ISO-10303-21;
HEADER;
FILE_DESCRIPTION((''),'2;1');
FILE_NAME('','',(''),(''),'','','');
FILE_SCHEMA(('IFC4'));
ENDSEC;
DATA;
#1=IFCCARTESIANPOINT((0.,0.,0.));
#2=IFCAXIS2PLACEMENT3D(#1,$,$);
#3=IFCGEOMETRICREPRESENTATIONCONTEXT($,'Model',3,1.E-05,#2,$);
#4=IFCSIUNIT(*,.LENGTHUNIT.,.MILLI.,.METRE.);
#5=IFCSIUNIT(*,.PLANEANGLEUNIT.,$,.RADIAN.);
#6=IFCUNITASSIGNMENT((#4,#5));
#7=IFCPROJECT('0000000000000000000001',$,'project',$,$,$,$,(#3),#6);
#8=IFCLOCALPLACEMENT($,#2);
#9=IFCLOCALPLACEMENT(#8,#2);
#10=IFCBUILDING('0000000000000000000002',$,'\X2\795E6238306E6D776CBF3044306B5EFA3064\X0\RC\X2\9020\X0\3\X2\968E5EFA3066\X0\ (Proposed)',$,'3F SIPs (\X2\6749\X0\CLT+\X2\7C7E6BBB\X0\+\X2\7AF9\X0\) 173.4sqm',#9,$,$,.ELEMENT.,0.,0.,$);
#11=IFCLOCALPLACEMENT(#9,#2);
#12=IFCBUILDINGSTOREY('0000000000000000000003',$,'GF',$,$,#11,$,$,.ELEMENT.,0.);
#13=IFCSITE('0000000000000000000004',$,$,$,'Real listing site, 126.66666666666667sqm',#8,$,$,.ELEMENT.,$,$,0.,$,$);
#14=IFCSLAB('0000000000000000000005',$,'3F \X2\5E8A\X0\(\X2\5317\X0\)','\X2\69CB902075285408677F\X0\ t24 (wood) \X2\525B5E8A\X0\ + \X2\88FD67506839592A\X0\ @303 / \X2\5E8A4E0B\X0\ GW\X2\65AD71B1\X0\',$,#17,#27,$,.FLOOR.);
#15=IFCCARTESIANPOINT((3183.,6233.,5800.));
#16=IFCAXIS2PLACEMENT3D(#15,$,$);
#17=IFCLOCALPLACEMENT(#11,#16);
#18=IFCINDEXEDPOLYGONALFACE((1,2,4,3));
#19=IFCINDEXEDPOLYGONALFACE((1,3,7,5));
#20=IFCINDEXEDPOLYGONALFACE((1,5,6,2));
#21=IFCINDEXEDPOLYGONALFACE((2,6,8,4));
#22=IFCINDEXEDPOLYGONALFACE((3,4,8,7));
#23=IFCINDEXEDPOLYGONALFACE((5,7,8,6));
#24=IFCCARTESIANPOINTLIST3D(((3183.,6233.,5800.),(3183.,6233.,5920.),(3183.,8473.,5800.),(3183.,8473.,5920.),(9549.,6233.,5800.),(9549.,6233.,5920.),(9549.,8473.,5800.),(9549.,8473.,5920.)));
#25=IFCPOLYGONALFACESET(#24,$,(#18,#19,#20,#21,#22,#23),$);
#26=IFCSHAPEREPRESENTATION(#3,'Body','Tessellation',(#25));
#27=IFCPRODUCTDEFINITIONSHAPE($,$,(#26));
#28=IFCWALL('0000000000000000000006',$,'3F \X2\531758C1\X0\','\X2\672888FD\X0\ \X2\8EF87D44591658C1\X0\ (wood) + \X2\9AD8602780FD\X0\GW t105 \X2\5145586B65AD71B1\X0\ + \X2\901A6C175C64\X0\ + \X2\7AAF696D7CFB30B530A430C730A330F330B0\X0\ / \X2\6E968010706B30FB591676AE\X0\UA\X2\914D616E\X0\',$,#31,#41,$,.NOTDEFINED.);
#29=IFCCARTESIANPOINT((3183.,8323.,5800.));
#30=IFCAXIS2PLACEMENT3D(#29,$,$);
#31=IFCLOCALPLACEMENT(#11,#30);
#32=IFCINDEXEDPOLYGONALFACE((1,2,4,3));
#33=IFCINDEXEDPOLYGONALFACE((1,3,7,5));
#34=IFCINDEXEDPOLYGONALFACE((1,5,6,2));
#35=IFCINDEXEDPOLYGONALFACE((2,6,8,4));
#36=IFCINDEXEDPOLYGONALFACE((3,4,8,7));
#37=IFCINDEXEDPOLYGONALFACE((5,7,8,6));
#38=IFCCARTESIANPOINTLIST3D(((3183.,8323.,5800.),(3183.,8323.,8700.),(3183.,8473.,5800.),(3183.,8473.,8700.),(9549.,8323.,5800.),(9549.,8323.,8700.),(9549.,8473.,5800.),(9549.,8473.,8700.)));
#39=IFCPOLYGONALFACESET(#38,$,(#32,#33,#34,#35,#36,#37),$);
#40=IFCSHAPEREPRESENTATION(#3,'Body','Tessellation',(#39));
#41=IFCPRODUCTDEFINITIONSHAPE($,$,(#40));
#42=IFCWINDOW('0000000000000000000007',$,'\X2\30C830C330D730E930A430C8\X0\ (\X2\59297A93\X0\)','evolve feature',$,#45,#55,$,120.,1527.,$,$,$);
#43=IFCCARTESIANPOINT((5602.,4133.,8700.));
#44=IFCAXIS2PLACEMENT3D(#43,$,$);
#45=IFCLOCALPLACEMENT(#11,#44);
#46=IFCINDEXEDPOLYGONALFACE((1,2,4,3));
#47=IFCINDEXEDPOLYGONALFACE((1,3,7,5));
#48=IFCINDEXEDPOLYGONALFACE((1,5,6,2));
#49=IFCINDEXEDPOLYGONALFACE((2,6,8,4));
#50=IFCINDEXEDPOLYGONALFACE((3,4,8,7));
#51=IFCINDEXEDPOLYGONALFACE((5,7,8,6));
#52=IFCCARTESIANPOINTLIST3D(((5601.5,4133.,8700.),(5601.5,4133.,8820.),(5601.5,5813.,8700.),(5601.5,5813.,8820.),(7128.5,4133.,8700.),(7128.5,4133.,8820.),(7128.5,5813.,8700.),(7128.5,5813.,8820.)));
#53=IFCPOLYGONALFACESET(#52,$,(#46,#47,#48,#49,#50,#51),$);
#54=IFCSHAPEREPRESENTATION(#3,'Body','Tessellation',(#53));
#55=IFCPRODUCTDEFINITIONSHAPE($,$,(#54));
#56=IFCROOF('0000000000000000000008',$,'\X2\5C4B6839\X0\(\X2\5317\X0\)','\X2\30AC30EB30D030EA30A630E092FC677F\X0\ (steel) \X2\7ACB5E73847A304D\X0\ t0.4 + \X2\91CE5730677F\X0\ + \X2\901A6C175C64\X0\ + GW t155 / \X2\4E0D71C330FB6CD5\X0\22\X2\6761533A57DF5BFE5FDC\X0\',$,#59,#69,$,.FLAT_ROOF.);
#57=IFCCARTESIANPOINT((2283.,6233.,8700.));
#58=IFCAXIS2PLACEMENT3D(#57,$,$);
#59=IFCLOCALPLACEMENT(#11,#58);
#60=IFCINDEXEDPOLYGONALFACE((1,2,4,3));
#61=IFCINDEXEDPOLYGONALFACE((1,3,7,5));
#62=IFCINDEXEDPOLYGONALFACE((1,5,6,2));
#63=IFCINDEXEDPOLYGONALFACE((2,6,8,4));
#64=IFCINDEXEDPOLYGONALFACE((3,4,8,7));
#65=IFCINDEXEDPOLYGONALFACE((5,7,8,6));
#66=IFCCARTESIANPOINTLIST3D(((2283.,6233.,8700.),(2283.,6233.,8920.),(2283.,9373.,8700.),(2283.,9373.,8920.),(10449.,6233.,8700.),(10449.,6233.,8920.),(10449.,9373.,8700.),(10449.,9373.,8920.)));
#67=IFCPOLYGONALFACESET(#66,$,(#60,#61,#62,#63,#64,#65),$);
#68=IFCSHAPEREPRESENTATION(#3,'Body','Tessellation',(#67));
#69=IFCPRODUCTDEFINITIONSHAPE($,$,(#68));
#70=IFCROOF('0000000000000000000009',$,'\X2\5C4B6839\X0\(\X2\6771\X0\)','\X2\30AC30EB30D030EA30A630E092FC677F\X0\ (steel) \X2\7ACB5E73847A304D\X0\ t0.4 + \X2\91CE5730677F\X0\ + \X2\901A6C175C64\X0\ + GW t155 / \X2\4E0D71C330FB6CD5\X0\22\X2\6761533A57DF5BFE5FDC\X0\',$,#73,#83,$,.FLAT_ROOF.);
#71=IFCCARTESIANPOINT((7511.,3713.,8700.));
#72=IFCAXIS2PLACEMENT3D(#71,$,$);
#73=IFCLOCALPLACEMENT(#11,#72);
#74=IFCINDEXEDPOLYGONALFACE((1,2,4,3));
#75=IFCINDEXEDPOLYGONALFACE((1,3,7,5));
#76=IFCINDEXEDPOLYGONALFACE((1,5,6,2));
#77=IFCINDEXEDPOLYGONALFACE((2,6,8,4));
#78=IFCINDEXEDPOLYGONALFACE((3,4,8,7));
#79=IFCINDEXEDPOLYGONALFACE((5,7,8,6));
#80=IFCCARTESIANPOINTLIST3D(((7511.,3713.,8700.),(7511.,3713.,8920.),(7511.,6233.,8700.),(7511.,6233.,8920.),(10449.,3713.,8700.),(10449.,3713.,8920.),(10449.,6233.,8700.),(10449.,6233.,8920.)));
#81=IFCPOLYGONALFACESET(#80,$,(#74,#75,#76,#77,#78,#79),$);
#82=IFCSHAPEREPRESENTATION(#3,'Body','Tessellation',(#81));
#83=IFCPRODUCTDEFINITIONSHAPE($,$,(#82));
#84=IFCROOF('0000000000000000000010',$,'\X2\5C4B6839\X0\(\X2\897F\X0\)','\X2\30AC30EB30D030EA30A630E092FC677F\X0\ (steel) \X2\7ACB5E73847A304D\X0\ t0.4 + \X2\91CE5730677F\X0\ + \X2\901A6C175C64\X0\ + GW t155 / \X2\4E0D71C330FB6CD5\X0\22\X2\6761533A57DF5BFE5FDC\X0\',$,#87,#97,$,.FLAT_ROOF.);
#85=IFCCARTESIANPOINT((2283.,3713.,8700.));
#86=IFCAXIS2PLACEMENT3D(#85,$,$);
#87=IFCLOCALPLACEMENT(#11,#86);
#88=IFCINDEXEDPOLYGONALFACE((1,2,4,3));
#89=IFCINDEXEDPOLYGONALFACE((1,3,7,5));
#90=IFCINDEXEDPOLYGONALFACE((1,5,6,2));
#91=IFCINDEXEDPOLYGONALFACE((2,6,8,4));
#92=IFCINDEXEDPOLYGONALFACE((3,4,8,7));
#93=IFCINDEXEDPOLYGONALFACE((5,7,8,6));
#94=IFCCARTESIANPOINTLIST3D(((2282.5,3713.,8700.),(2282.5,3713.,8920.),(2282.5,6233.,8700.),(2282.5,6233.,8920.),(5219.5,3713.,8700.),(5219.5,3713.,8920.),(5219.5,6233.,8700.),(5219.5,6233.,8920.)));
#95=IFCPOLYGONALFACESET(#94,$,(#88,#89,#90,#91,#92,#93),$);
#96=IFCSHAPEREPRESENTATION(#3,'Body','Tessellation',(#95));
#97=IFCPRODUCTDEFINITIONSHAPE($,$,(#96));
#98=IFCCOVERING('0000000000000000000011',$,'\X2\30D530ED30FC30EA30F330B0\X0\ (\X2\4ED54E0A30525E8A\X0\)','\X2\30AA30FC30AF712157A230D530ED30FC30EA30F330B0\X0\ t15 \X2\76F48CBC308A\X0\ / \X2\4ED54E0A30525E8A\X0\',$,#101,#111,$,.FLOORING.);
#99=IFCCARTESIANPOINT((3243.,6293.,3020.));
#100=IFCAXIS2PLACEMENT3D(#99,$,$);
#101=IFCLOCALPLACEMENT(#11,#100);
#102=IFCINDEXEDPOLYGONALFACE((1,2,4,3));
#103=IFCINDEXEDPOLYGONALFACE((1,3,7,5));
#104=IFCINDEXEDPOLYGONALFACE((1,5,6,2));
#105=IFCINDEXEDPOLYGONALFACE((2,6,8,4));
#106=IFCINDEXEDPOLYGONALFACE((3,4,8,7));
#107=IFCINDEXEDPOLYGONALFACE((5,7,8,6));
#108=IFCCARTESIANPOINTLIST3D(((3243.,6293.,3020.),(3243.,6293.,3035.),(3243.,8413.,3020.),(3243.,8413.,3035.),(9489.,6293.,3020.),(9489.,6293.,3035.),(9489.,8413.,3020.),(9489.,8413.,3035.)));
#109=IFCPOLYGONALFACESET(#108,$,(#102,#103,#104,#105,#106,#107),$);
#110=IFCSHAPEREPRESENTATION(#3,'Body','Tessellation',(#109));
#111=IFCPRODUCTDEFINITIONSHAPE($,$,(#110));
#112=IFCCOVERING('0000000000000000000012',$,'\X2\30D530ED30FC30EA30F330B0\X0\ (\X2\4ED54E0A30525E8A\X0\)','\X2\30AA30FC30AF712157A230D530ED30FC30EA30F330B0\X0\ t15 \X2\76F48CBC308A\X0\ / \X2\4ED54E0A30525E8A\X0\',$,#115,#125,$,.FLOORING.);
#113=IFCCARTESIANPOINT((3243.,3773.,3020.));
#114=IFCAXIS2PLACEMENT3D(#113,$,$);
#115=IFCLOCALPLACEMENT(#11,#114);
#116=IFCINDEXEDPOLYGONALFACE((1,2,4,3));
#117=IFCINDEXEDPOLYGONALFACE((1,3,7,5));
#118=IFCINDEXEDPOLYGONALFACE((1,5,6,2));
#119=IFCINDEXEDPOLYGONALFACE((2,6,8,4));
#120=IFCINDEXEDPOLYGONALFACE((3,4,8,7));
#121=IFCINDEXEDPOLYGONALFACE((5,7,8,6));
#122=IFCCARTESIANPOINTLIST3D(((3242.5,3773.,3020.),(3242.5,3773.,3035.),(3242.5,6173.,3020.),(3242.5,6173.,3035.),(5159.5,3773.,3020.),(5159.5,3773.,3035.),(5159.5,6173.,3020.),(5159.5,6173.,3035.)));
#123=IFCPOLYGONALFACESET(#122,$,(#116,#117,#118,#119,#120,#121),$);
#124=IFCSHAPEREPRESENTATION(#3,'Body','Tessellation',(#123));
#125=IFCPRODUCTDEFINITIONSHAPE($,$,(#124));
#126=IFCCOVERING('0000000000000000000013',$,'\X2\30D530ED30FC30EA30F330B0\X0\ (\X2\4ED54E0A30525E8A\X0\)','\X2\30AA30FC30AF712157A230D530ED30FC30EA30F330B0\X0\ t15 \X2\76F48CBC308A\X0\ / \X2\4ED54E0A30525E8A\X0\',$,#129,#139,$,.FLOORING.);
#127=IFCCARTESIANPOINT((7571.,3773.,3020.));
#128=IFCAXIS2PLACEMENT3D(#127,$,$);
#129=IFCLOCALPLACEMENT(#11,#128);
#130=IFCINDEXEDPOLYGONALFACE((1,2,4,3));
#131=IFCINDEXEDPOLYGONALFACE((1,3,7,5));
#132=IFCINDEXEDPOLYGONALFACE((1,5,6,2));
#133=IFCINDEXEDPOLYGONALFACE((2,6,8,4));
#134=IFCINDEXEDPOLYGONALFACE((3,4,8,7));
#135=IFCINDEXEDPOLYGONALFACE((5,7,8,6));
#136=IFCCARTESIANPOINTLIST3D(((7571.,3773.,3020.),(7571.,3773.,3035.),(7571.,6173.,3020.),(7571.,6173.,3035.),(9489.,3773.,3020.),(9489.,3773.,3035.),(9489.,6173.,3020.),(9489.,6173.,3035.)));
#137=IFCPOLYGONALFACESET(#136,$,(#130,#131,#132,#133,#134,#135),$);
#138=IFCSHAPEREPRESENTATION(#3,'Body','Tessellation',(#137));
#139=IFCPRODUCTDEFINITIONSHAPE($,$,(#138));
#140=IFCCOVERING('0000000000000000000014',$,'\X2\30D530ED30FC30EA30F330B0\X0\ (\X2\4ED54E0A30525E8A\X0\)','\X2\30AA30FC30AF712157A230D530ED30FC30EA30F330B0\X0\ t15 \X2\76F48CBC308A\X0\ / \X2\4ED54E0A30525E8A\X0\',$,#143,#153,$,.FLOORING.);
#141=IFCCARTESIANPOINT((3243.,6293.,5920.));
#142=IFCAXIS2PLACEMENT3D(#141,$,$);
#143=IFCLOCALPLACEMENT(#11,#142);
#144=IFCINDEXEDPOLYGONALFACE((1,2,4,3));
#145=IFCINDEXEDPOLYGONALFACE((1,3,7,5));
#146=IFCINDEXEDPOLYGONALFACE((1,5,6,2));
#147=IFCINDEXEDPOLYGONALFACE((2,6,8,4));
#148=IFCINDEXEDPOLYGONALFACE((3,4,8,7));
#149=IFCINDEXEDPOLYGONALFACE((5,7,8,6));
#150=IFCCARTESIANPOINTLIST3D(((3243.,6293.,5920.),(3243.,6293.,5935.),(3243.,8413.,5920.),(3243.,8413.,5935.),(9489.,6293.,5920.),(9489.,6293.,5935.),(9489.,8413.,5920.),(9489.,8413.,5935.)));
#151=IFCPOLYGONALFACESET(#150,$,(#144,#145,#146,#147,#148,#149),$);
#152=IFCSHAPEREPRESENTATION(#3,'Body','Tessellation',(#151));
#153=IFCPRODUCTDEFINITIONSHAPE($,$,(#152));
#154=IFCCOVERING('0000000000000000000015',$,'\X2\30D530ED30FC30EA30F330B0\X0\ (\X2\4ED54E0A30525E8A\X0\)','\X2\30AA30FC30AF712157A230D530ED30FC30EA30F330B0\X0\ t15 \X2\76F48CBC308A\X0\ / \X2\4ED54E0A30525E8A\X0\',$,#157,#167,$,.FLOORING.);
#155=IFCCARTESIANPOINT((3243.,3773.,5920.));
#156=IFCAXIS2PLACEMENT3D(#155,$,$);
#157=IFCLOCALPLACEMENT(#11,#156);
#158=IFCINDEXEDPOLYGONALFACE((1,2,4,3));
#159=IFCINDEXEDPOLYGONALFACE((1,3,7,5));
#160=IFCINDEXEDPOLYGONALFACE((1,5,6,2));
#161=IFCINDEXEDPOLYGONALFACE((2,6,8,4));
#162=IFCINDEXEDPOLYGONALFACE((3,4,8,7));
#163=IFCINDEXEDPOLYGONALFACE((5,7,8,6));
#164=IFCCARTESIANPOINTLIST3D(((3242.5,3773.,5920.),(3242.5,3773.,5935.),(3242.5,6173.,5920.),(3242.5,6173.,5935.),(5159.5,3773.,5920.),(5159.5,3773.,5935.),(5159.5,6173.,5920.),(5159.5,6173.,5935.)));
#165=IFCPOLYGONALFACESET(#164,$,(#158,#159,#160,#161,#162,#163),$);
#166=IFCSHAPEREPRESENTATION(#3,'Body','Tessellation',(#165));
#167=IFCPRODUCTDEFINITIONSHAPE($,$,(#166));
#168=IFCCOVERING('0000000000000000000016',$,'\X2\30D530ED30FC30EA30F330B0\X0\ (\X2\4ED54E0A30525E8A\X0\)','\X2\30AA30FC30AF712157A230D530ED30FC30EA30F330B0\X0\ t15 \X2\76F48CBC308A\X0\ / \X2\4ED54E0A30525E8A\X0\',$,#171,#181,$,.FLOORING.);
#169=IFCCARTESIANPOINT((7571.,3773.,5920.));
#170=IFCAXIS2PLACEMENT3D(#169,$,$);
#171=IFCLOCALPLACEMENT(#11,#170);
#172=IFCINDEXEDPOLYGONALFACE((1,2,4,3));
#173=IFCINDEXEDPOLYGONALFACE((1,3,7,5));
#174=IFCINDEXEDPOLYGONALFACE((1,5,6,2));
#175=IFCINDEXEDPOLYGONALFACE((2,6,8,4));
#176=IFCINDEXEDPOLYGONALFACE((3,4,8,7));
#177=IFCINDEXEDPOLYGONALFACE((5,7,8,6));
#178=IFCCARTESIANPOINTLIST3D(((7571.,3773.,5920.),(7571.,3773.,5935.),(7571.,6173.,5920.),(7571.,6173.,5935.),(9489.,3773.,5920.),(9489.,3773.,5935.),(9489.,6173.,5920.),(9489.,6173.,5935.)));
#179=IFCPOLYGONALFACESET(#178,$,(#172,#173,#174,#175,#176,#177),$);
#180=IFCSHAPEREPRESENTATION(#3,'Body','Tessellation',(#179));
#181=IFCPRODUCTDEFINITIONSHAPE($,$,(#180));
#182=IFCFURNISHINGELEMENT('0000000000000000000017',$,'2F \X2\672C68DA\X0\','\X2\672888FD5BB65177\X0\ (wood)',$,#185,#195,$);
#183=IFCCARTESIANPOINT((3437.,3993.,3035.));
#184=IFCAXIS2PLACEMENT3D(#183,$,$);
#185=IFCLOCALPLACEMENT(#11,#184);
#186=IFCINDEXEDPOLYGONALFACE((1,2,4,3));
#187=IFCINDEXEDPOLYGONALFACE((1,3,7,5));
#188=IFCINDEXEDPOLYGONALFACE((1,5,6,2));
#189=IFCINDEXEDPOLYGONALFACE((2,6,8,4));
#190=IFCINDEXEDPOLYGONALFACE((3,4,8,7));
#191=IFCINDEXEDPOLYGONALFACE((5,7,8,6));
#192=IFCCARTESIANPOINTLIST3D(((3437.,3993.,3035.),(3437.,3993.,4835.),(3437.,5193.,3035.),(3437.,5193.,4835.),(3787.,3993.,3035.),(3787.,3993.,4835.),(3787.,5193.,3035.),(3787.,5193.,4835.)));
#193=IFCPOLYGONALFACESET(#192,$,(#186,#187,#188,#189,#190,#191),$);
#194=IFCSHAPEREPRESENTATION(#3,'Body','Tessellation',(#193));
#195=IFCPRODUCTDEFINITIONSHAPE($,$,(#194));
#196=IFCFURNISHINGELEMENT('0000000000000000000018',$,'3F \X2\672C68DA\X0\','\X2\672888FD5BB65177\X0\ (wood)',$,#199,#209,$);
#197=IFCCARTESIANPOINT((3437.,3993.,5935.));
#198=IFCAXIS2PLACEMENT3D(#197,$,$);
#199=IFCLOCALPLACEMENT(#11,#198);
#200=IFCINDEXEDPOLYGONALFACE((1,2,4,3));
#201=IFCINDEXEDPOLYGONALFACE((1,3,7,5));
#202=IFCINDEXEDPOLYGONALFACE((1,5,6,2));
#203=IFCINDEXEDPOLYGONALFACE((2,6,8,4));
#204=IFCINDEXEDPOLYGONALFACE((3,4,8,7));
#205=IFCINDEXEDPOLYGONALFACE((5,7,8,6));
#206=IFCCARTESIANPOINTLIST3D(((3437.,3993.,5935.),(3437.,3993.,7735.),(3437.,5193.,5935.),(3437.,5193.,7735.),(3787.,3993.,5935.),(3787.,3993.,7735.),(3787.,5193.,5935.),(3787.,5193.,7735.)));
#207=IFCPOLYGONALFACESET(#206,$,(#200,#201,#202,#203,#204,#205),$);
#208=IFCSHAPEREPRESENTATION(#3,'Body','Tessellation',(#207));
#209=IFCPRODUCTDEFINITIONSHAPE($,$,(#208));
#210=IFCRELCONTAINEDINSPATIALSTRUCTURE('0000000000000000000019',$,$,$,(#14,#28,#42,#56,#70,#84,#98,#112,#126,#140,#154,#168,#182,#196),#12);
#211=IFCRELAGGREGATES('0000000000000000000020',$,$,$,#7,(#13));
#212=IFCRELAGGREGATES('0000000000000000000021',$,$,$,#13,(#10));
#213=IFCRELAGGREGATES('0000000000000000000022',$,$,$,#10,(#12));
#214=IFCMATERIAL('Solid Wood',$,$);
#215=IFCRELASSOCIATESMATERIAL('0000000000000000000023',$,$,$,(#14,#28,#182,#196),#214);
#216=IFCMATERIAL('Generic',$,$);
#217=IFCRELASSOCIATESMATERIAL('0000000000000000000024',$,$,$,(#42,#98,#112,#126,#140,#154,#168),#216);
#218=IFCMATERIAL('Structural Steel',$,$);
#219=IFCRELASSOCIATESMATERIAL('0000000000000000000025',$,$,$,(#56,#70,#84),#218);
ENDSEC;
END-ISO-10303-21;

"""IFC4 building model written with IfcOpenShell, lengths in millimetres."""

from ifc_helpers import new_model, si_unit, frame, frame_2d, origin, place, context, project, spatial, rectangle, extrude, material, element, save


model = new_model("IFC4")

# Units and contexts
model_context = context("Model", 3, precision=1e-05, world=origin())
ifc_project = project(units=[si_unit("LENGTHUNIT", "METRE", prefix="MILLI"), si_unit("PLANEANGLEUNIT", "RADIAN")], contexts=[model_context])

# Site, building, storey
site_placement = place(None, origin())
site = spatial("IfcSite", under=ifc_project, at=site_placement, ObjectType="Real listing site, 126.66666666666667sqm", CompositionType="ELEMENT", RefElevation=0.0)
building_placement = place(site_placement, origin())
building = spatial("IfcBuilding", under=site, at=building_placement, Name="神戸の海沿いに建つRC造3階建て (Proposed)", ObjectType="3F SIPs (杉CLT+籾殻+竹) 173.4sqm", CompositionType="ELEMENT", ElevationOfRefHeight=0.0, ElevationOfTerrain=0.0)
storey_placement = place(building_placement, origin())
storey = spatial("IfcBuildingStorey", under=building, at=storey_placement, Name="GF", CompositionType="ELEMENT", Elevation=0.0)

# Slab
ifc_material_1 = material(Name="Solid Wood")
slab_placement = place(storey_placement, frame((3183.0, 6233.0, 5800.0)))
element("IfcSlab", 1, at=slab_placement, inside=storey, material=ifc_material_1, Name="3F 床(北)", Description="構造用合板 t24 (wood) 剛床 + 製材根太 @303 / 床下 GW断熱", PredefinedType="FLOOR", context=model_context, shape_type="SweptSolid", body=[
    extrude(rectangle(XDim=6366.0, YDim=2240.0, at=frame_2d((3183.0, 1120.0))), frame((3183.0, 6233.0, 5800.0)), (0.0, 0.0, 1.0), 120.0),
])

# Wall
wall_1_placement = place(storey_placement, frame((3183.0, 8323.0, 5800.0)))
element("IfcWall", 2, at=wall_1_placement, inside=storey, material=ifc_material_1, Name="3F 北壁", Description="木製 軸組外壁 (wood) + 高性能GW t105 充填断熱 + 通気層 + 窯業系サイディング / 準耐火・外皮UA配慮", PredefinedType="NOTDEFINED", context=model_context, shape_type="SweptSolid", body=[
    extrude(rectangle(XDim=6366.0, YDim=150.0, at=frame_2d((3183.0, 75.0))), frame((3183.0, 8323.0, 5800.0)), (0.0, 0.0, 1.0), 2900.0),
])

# Window
ifc_material_2 = material(Name="Generic")
window_1_placement = place(storey_placement, frame((5602.0, 4133.0, 8700.0)))
element("IfcWindow", 3, at=window_1_placement, inside=storey, material=ifc_material_2, Name="トップライト (天窓)", Description="evolve feature", OverallHeight=120.0, OverallWidth=1527.0, context=model_context, shape_type="SweptSolid", body=[
    extrude(rectangle(XDim=1527.0, YDim=1680.0, at=frame_2d((763.0, 840.0))), frame((5602.0, 4133.0, 8700.0)), (0.0, 0.0, 1.0), 120.0),
])

# Roofs
ifc_material_3 = material(Name="Structural Steel")
roof_1_placement = place(storey_placement, frame((2283.0, 6233.0, 8700.0)))
element("IfcRoof", 4, at=roof_1_placement, inside=storey, material=ifc_material_3, Name="屋根(北)", Description="ガルバリウム鋼板 (steel) 立平葺き t0.4 + 野地板 + 通気層 + GW t155 / 不燃・法22条区域対応", PredefinedType="FLAT_ROOF", context=model_context, shape_type="SweptSolid", body=[
    extrude(rectangle(XDim=8166.0, YDim=3140.0, at=frame_2d((4083.0, 1570.0))), frame((2283.0, 6233.0, 8700.0)), (0.0, 0.0, 1.0), 220.0),
])
roof_2_placement = place(storey_placement, frame((7511.0, 3713.0, 8700.0)))
element("IfcRoof", 5, at=roof_2_placement, inside=storey, material=ifc_material_3, Name="屋根(東)", Description="ガルバリウム鋼板 (steel) 立平葺き t0.4 + 野地板 + 通気層 + GW t155 / 不燃・法22条区域対応", PredefinedType="FLAT_ROOF", context=model_context, shape_type="SweptSolid", body=[
    extrude(rectangle(XDim=2938.0, YDim=2520.0, at=frame_2d((1469.0, 1260.0))), frame((7511.0, 3713.0, 8700.0)), (0.0, 0.0, 1.0), 220.0),
])
roof_3_placement = place(storey_placement, frame((2283.0, 3713.0, 8700.0)))
element("IfcRoof", 6, at=roof_3_placement, inside=storey, material=ifc_material_3, Name="屋根(西)", Description="ガルバリウム鋼板 (steel) 立平葺き t0.4 + 野地板 + 通気層 + GW t155 / 不燃・法22条区域対応", PredefinedType="FLAT_ROOF", context=model_context, shape_type="SweptSolid", body=[
    extrude(rectangle(XDim=2937.0, YDim=2520.0, at=frame_2d((1468.0, 1260.0))), frame((2283.0, 3713.0, 8700.0)), (0.0, 0.0, 1.0), 220.0),
])

# Coverings
covering_1_placement = place(storey_placement, frame((3243.0, 6293.0, 3020.0)))
element("IfcCovering", 7, at=covering_1_placement, inside=storey, material=ifc_material_2, Name="フローリング (仕上げ床)", Description="オーク無垢フローリング t15 直貼り / 仕上げ床", PredefinedType="FLOORING", context=model_context, shape_type="SweptSolid", body=[
    extrude(rectangle(XDim=6246.0, YDim=2120.0, at=frame_2d((3123.0, 1060.0))), frame((3243.0, 6293.0, 3020.0)), (0.0, 0.0, 1.0), 15.0),
])
covering_2_placement = place(storey_placement, frame((3243.0, 3773.0, 3020.0)))
element("IfcCovering", 8, at=covering_2_placement, inside=storey, material=ifc_material_2, Name="フローリング (仕上げ床)", Description="オーク無垢フローリング t15 直貼り / 仕上げ床", PredefinedType="FLOORING", context=model_context, shape_type="SweptSolid", body=[
    extrude(rectangle(XDim=1917.0, YDim=2400.0, at=frame_2d((958.0, 1200.0))), frame((3243.0, 3773.0, 3020.0)), (0.0, 0.0, 1.0), 15.0),
])
covering_3_placement = place(storey_placement, frame((7571.0, 3773.0, 3020.0)))
element("IfcCovering", 9, at=covering_3_placement, inside=storey, material=ifc_material_2, Name="フローリング (仕上げ床)", Description="オーク無垢フローリング t15 直貼り / 仕上げ床", PredefinedType="FLOORING", context=model_context, shape_type="SweptSolid", body=[
    extrude(rectangle(XDim=1918.0, YDim=2400.0, at=frame_2d((959.0, 1200.0))), frame((7571.0, 3773.0, 3020.0)), (0.0, 0.0, 1.0), 15.0),
])
covering_4_placement = place(storey_placement, frame((3243.0, 6293.0, 5920.0)))
element("IfcCovering", 10, at=covering_4_placement, inside=storey, material=ifc_material_2, Name="フローリング (仕上げ床)", Description="オーク無垢フローリング t15 直貼り / 仕上げ床", PredefinedType="FLOORING", context=model_context, shape_type="SweptSolid", body=[
    extrude(rectangle(XDim=6246.0, YDim=2120.0, at=frame_2d((3123.0, 1060.0))), frame((3243.0, 6293.0, 5920.0)), (0.0, 0.0, 1.0), 15.0),
])
covering_5_placement = place(storey_placement, frame((3243.0, 3773.0, 5920.0)))
element("IfcCovering", 11, at=covering_5_placement, inside=storey, material=ifc_material_2, Name="フローリング (仕上げ床)", Description="オーク無垢フローリング t15 直貼り / 仕上げ床", PredefinedType="FLOORING", context=model_context, shape_type="SweptSolid", body=[
    extrude(rectangle(XDim=1917.0, YDim=2400.0, at=frame_2d((958.0, 1200.0))), frame((3243.0, 3773.0, 5920.0)), (0.0, 0.0, 1.0), 15.0),
])
covering_6_placement = place(storey_placement, frame((7571.0, 3773.0, 5920.0)))
element("IfcCovering", 12, at=covering_6_placement, inside=storey, material=ifc_material_2, Name="フローリング (仕上げ床)", Description="オーク無垢フローリング t15 直貼り / 仕上げ床", PredefinedType="FLOORING", context=model_context, shape_type="SweptSolid", body=[
    extrude(rectangle(XDim=1918.0, YDim=2400.0, at=frame_2d((959.0, 1200.0))), frame((7571.0, 3773.0, 5920.0)), (0.0, 0.0, 1.0), 15.0),
])

# Furnishing elements
furnishing_1_placement = place(storey_placement, frame((3437.0, 3993.0, 3035.0)))
element("IfcFurnishingElement", 13, at=furnishing_1_placement, inside=storey, material=ifc_material_1, Name="2F 本棚", Description="木製家具 (wood)", context=model_context, shape_type="SweptSolid", body=[
    extrude(rectangle(XDim=350.0, YDim=1200.0, at=frame_2d((175.0, 600.0))), frame((3437.0, 3993.0, 3035.0)), (0.0, 0.0, 1.0), 1800.0),
])
furnishing_2_placement = place(storey_placement, frame((3437.0, 3993.0, 5935.0)))
element("IfcFurnishingElement", 14, at=furnishing_2_placement, inside=storey, material=ifc_material_1, Name="3F 本棚", Description="木製家具 (wood)", context=model_context, shape_type="SweptSolid", body=[
    extrude(rectangle(XDim=350.0, YDim=1200.0, at=frame_2d((175.0, 600.0))), frame((3437.0, 3993.0, 5935.0)), (0.0, 0.0, 1.0), 1800.0),
])

save(model, "model.ifc")
